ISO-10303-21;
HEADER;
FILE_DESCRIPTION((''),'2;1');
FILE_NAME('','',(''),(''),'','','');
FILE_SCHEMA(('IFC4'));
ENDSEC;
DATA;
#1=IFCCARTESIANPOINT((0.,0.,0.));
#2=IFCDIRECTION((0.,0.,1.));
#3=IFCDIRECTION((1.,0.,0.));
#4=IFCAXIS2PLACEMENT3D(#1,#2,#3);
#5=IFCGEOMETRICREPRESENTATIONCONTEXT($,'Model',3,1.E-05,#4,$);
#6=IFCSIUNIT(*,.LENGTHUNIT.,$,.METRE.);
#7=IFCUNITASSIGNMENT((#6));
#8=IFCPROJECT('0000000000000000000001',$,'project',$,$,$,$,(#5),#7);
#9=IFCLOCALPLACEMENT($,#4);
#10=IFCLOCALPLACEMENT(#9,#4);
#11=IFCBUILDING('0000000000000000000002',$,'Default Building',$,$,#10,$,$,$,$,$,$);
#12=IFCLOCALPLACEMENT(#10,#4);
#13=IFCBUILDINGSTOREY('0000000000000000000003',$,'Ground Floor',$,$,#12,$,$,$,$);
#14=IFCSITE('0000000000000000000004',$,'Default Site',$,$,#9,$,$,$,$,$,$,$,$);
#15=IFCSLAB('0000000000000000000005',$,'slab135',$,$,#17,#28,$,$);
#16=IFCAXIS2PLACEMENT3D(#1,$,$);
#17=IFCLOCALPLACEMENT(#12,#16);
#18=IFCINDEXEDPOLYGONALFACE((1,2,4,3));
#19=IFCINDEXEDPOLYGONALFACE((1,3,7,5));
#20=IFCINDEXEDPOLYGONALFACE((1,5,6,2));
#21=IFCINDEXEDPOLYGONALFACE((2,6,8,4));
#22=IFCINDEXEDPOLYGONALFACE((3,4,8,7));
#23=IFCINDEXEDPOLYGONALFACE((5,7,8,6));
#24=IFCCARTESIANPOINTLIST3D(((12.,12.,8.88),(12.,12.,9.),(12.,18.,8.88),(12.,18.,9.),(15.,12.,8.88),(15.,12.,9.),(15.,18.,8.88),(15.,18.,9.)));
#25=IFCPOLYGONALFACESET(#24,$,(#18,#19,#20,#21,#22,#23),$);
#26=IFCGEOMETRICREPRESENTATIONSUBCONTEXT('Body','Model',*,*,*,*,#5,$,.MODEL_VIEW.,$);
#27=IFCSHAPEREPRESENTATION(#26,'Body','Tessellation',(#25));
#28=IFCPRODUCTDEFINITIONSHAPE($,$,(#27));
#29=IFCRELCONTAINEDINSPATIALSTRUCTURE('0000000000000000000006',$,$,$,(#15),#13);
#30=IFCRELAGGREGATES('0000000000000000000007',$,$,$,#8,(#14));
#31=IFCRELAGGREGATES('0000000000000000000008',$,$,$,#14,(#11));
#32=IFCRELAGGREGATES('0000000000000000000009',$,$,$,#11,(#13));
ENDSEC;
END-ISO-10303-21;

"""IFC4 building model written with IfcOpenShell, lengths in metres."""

from ifc_helpers import new_model, si_unit, frame, origin_with_axes, place, context, subcontext, project, spatial, indexed_curve, outline, extrude, element, save


model = new_model("IFC4")

# Units and contexts
model_context = context("Model", 3, precision=1e-05, world=origin_with_axes())
body_context = subcontext(model_context, "Body", "Model", "MODEL_VIEW")
ifc_project = project(units=[si_unit("LENGTHUNIT", "METRE")], contexts=[model_context])

# Site, building, storey
site_placement = place(None, origin_with_axes())
site = spatial("IfcSite", under=ifc_project, at=site_placement, Name="Default Site")
building_placement = place(site_placement, origin_with_axes())
building = spatial("IfcBuilding", under=site, at=building_placement, Name="Default Building")
storey_placement = place(building_placement, origin_with_axes())
storey = spatial("IfcBuildingStorey", under=building, at=storey_placement, Name="Ground Floor")

# Slab
for number, where, z_axis, x_axis, name in (
    (1, (12.0, 12.0, 8.88), (0.0, 0.0, 1.0), (1.0, 0.0, 0.0), "slab135"),
):
    element("IfcSlab", number, at=place(storey_placement, frame(where, z_axis=z_axis, x_axis=x_axis)), inside=storey, Name=name, context=body_context, shape_type="SweptSolid", body=[
        extrude(outline(indexed_curve([(0.0, 0.0), (0.0, 6.0), (3.0, 6.0), (3.0, 0.0), (0.0, 0.0)], self_intersect=False)), origin_with_axes(), (0.0, 0.0, 1.0), 0.12),
    ])

save(model, "model.ifc")
